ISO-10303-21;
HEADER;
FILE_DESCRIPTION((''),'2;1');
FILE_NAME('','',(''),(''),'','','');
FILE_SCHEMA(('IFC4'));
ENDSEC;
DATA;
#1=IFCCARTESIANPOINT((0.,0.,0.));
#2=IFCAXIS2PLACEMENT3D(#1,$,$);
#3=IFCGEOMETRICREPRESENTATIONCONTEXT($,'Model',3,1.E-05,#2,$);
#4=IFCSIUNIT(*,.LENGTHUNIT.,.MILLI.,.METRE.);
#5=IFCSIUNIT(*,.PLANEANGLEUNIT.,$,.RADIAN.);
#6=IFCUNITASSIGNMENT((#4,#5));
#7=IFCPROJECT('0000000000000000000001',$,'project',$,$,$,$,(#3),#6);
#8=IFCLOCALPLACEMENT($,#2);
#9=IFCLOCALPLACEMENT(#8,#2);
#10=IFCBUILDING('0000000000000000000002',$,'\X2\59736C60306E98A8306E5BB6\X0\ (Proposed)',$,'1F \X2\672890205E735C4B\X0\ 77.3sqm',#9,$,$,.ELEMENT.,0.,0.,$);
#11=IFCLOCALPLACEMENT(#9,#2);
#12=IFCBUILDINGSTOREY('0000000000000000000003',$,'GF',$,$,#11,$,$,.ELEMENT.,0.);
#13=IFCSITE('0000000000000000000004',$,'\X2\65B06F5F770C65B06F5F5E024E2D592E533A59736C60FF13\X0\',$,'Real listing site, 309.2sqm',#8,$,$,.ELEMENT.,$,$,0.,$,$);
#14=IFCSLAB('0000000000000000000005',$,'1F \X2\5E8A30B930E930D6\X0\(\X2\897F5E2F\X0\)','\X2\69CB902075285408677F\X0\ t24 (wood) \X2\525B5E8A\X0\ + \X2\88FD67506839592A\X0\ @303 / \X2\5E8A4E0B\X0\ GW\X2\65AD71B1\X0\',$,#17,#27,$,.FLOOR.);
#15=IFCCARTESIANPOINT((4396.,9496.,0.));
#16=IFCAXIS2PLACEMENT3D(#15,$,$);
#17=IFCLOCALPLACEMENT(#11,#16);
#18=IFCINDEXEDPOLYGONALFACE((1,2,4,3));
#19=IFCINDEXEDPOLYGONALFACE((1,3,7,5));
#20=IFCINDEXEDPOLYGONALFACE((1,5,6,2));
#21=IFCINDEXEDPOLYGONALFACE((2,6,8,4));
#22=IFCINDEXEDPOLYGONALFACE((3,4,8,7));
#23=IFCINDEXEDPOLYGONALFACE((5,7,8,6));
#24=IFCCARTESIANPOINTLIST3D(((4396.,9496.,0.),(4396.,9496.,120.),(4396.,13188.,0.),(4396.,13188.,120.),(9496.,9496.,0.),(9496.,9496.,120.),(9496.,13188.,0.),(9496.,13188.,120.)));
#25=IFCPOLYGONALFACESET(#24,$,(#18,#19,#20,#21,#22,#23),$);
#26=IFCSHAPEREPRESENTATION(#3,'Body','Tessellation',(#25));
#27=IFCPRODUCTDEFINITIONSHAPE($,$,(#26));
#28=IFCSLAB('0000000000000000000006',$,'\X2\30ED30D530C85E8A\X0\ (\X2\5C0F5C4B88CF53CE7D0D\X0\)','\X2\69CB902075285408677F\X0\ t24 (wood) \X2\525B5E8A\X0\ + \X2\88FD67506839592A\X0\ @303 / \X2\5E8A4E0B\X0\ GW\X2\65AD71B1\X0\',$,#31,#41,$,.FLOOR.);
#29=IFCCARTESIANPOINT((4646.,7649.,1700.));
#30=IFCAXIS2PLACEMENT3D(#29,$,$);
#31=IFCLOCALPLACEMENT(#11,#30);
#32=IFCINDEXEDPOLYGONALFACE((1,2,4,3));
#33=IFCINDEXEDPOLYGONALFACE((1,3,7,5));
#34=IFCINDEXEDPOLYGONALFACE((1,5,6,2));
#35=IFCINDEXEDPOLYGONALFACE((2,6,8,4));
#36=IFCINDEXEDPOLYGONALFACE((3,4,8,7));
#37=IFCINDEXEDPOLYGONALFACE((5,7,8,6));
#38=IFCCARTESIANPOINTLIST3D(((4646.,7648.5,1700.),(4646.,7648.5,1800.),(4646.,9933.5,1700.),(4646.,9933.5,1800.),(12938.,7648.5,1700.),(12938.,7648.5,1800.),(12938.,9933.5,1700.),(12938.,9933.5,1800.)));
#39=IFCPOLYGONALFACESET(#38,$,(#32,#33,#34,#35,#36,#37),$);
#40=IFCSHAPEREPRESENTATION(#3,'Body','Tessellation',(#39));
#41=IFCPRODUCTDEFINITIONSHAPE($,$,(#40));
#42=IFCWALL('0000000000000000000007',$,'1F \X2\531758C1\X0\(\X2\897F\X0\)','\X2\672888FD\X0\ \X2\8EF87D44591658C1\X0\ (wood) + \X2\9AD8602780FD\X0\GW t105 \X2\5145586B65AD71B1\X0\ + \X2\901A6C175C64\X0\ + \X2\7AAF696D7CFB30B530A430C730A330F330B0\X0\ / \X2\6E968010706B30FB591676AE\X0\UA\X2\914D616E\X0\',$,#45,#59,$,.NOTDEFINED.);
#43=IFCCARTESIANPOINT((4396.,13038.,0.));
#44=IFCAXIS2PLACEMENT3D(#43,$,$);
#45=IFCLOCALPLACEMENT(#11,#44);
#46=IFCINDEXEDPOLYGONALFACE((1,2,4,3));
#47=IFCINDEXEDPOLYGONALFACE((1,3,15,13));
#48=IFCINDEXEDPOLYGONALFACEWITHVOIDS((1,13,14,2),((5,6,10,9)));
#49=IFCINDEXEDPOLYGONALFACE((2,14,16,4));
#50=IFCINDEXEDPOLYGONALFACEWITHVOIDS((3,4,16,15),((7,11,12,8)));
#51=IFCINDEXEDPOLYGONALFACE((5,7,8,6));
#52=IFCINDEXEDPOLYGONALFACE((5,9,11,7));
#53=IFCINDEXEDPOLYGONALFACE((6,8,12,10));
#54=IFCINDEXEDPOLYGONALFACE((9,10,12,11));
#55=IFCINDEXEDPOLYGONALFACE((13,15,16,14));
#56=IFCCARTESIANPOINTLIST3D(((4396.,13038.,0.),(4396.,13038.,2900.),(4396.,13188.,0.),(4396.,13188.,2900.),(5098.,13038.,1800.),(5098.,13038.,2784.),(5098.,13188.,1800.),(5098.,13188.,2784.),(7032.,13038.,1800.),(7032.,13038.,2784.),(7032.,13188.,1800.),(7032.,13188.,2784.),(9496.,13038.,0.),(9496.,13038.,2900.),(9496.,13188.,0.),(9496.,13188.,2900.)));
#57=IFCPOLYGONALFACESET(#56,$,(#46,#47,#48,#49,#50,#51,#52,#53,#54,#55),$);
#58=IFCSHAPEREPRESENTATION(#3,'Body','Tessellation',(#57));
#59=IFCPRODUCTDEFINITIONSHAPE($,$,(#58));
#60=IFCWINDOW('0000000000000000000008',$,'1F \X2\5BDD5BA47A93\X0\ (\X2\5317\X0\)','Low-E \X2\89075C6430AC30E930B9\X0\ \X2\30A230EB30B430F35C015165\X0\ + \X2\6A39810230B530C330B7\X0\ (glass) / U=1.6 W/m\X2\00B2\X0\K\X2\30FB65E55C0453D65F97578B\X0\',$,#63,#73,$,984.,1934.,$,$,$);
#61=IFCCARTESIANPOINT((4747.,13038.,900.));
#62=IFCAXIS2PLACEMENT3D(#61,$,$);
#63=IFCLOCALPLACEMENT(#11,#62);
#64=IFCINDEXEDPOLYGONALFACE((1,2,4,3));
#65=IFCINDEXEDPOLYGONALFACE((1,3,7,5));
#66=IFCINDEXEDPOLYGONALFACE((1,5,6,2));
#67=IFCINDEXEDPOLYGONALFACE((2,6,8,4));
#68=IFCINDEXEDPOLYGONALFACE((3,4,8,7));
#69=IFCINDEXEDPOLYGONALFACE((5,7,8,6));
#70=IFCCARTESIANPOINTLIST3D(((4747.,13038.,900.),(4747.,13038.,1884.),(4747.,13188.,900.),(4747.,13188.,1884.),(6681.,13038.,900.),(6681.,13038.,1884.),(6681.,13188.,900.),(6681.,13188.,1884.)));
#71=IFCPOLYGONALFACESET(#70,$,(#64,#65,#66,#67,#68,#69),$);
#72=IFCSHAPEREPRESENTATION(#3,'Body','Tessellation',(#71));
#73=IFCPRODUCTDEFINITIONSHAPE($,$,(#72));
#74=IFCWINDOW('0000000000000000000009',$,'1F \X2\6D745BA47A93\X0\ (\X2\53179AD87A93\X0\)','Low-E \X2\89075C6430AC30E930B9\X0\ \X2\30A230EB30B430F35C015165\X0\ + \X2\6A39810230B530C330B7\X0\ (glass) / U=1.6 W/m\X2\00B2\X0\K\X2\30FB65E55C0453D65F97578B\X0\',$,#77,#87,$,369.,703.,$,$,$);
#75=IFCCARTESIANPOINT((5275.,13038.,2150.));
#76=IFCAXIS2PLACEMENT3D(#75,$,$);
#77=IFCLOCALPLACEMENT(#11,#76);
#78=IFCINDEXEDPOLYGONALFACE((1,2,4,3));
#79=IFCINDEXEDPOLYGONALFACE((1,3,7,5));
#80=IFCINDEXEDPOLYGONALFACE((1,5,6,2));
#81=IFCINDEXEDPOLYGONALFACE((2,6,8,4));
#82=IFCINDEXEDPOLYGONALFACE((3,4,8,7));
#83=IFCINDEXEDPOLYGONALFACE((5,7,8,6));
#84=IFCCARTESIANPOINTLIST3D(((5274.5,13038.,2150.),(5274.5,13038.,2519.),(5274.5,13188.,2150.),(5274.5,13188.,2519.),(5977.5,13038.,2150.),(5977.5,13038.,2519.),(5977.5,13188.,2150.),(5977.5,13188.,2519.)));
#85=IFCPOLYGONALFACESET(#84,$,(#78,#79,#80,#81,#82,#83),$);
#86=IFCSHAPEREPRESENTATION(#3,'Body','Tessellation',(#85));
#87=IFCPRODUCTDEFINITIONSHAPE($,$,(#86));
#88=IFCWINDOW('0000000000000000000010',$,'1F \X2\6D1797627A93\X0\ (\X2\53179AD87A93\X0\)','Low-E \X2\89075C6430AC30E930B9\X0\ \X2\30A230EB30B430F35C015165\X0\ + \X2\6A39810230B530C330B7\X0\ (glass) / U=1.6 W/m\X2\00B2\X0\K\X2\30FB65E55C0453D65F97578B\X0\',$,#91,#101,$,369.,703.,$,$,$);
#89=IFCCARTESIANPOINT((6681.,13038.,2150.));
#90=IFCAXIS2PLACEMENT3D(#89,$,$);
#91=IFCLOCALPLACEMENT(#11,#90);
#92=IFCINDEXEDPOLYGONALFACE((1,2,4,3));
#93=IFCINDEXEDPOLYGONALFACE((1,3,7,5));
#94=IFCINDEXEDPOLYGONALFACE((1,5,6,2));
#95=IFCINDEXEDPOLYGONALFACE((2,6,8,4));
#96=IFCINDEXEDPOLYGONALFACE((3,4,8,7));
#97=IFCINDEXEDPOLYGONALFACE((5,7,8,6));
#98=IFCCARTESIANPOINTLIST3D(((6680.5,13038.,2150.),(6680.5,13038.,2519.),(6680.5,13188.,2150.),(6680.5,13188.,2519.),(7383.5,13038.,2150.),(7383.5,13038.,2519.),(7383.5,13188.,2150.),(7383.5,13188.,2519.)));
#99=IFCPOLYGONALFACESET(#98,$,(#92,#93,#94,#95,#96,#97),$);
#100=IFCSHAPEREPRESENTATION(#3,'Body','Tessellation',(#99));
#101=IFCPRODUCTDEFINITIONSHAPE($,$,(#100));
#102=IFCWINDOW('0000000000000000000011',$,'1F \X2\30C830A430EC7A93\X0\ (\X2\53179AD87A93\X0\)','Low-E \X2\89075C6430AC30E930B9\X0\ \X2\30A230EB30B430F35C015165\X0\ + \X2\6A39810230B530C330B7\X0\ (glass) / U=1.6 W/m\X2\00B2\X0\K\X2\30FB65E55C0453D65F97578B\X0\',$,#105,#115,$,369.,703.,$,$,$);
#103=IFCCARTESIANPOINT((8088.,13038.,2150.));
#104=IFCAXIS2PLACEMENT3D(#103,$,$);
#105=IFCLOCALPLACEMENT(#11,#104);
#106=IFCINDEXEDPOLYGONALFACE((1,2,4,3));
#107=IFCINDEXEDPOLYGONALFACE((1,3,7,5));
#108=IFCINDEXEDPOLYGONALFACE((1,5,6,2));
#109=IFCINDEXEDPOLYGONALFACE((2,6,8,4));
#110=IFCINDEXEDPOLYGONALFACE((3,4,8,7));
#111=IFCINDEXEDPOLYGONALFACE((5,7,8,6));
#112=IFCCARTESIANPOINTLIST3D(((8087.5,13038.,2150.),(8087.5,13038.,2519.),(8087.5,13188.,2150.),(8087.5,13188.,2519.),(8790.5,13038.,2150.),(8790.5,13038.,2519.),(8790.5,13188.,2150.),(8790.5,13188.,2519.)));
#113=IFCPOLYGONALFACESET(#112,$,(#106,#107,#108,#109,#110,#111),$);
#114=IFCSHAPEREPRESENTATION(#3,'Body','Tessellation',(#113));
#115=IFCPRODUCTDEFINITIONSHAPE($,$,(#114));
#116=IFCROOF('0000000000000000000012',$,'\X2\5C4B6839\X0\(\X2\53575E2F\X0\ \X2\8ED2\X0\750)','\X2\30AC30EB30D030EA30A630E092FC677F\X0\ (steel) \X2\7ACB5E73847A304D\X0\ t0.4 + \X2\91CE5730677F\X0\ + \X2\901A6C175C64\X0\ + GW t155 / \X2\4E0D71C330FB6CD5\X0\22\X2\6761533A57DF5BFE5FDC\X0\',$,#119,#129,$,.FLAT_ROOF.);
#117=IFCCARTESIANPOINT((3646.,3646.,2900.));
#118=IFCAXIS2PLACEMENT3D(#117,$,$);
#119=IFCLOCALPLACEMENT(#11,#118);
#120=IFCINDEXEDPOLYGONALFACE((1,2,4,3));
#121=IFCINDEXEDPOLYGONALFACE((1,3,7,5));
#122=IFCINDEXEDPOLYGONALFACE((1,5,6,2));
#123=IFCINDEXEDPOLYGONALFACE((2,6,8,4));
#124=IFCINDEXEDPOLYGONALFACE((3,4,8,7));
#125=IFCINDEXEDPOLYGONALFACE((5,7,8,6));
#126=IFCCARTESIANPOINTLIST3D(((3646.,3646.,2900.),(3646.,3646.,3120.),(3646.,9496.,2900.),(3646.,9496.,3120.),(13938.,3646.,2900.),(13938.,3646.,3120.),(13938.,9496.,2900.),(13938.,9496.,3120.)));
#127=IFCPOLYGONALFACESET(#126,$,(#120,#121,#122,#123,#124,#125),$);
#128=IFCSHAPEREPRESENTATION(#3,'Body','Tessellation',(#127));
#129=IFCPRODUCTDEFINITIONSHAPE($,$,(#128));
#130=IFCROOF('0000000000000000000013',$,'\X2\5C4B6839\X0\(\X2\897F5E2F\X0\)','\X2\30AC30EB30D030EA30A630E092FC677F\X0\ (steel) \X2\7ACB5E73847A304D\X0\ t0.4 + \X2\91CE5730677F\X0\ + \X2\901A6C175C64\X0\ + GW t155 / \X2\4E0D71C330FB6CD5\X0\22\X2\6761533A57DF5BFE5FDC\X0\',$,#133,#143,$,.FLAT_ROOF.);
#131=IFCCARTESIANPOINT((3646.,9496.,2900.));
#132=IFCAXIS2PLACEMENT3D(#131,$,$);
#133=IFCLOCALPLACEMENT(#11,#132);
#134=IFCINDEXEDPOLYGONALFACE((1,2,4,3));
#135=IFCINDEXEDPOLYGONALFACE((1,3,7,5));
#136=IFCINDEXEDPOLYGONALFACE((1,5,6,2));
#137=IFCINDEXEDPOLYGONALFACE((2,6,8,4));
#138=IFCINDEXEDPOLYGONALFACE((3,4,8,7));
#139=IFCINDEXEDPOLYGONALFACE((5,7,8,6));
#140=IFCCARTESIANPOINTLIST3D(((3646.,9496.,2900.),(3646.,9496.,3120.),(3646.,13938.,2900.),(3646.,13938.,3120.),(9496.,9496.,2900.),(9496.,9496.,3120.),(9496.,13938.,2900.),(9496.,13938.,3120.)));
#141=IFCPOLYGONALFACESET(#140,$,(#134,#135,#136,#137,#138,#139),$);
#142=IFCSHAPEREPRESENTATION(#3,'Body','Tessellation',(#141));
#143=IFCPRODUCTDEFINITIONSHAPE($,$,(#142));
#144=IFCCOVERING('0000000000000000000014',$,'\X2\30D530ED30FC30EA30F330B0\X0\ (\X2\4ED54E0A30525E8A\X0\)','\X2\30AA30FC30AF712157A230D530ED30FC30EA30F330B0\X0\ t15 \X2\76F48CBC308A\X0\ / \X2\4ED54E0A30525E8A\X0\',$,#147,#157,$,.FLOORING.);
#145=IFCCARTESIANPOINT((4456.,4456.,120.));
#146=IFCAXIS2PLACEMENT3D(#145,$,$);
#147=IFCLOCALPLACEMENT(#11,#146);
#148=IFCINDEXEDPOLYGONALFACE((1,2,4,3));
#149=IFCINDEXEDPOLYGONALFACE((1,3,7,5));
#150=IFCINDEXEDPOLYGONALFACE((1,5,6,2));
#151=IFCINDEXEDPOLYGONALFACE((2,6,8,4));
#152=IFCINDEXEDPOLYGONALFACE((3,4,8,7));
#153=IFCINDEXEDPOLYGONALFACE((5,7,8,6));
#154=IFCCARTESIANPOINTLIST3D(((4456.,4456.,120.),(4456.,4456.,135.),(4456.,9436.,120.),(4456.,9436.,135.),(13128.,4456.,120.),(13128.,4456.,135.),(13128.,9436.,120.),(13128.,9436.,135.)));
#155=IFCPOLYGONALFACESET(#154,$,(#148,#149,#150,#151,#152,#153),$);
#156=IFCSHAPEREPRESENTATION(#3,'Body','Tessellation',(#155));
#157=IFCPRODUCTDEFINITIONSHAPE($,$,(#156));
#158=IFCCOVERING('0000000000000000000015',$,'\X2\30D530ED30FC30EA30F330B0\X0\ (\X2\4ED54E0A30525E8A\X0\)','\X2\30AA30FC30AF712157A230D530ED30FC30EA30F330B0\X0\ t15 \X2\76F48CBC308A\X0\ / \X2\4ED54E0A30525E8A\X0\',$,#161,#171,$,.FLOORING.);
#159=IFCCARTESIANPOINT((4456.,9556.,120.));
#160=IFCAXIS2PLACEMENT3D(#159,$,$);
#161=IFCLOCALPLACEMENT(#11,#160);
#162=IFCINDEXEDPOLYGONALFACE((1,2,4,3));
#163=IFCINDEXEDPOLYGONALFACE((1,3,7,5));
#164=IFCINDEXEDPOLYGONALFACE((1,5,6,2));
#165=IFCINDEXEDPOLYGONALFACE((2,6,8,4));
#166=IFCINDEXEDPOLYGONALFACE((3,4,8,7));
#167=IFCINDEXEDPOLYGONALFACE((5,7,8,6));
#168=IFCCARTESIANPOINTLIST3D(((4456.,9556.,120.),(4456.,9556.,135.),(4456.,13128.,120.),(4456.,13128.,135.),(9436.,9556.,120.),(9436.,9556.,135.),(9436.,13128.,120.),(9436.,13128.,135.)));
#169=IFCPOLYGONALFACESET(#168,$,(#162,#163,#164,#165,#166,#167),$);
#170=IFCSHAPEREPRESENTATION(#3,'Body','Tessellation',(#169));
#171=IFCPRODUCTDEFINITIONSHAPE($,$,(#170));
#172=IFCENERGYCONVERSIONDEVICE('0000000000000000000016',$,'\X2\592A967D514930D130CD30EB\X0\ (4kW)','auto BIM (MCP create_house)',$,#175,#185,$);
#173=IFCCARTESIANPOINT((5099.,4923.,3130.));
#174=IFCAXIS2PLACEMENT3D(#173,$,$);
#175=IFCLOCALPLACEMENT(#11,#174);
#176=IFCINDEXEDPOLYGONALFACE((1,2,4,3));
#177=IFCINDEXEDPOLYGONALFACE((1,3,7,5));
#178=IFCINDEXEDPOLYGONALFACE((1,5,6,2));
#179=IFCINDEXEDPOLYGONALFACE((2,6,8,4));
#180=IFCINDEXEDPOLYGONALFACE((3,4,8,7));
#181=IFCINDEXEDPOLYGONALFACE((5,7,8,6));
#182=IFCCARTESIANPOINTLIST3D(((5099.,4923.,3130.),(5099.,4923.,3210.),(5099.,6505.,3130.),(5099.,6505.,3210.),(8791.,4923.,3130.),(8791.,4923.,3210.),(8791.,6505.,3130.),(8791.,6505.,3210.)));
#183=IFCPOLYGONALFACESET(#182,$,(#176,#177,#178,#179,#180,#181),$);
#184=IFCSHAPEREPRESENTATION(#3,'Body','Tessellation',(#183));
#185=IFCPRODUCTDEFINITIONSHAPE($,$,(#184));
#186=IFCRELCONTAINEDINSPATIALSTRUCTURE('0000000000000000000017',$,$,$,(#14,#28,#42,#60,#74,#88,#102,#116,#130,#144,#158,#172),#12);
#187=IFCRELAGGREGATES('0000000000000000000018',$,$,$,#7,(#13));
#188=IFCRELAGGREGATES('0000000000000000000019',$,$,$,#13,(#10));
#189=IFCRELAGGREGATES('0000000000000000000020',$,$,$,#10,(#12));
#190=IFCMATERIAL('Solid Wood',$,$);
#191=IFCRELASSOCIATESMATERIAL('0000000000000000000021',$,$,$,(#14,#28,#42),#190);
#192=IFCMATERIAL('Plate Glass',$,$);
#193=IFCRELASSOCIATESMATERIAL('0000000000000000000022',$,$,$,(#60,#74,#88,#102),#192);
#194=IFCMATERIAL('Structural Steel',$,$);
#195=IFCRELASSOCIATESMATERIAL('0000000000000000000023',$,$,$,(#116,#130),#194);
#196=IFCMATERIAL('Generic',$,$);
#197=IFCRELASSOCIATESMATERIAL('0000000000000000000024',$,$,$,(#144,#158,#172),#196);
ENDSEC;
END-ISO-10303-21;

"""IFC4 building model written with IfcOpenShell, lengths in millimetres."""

from ifc_helpers import new_model, si_unit, frame, frame_2d, origin, place, context, project, spatial, rectangle, extrude, material, element, fill, save


model = new_model("IFC4")

# Units and contexts
model_context = context("Model", 3, precision=1e-05, world=origin())
ifc_project = project(units=[si_unit("LENGTHUNIT", "METRE", prefix="MILLI"), si_unit("PLANEANGLEUNIT", "RADIAN")], contexts=[model_context])

# Site, building, storey
site_placement = place(None, origin())
site = spatial("IfcSite", under=ifc_project, at=site_placement, Name="新潟県新潟市中央区女池３", ObjectType="Real listing site, 309.2sqm", CompositionType="ELEMENT", RefElevation=0.0)
building_placement = place(site_placement, origin())
building = spatial("IfcBuilding", under=site, at=building_placement, Name="女池の風の家 (Proposed)", ObjectType="1F 木造平屋 77.3sqm", CompositionType="ELEMENT", ElevationOfRefHeight=0.0, ElevationOfTerrain=0.0)
storey_placement = place(building_placement, origin())
storey = spatial("IfcBuildingStorey", under=building, at=storey_placement, Name="GF", CompositionType="ELEMENT", Elevation=0.0)

# Slabs
ifc_material_1 = material(Name="Solid Wood")
slab_1_placement = place(storey_placement, frame((4396.0, 9496.0, 0.0)))
element("IfcSlab", 1, at=slab_1_placement, inside=storey, material=ifc_material_1, Name="1F 床スラブ(西帯)", Description="構造用合板 t24 (wood) 剛床 + 製材根太 @303 / 床下 GW断熱", PredefinedType="FLOOR", context=model_context, shape_type="SweptSolid", body=[
    extrude(rectangle(XDim=5100.0, YDim=3692.0, at=frame_2d((2550.0, 1846.0))), frame((4396.0, 9496.0, 0.0)), (0.0, 0.0, 1.0), 120.0),
])
slab_2_placement = place(storey_placement, frame((4646.0, 7649.0, 1700.0)))
element("IfcSlab", 2, at=slab_2_placement, inside=storey, material=ifc_material_1, Name="ロフト床 (小屋裏収納)", Description="構造用合板 t24 (wood) 剛床 + 製材根太 @303 / 床下 GW断熱", PredefinedType="FLOOR", context=model_context, shape_type="SweptSolid", body=[
    extrude(rectangle(XDim=8292.0, YDim=2285.0, at=frame_2d((4146.0, 1142.0))), frame((4646.0, 7649.0, 1700.0)), (0.0, 0.0, 1.0), 100.0),
])

# Shared definitions
ifc_material_2 = material(Name="Plate Glass")

# Wall, openings, windows
wall_1_placement = place(storey_placement, frame((4396.0, 13038.0, 0.0)))
wall_1 = element("IfcWall", 3, at=wall_1_placement, inside=storey, material=ifc_material_1, Name="1F 北壁(西)", Description="木製 軸組外壁 (wood) + 高性能GW t105 充填断熱 + 通気層 + 窯業系サイディング / 準耐火・外皮UA配慮", PredefinedType="NOTDEFINED", context=model_context, shape_type="SweptSolid", body=[
    extrude(rectangle(XDim=5100.0, YDim=150.0, at=frame_2d((2550.0, 75.0))), frame((4396.0, 13038.0, 0.0)), (0.0, 0.0, 1.0), 2900.0),
])
opening_1_placement = place(storey_placement, frame((4747.0, 13038.0, 900.0)))
opening_1 = element("IfcOpeningElement", 4, at=opening_1_placement, cuts=wall_1, PredefinedType="NOTDEFINED", context=model_context, shape_type="SweptSolid", body=[
    extrude(rectangle(XDim=1934.0, YDim=150.0, at=frame_2d((967.0, 75.0))), frame((4747.0, 13038.0, 900.0)), (0.0, 0.0, 1.0), 984.0),
])
opening_2_placement = place(storey_placement, frame((5275.0, 13038.0, 2150.0)))
opening_2 = element("IfcOpeningElement", 5, at=opening_2_placement, cuts=wall_1, PredefinedType="NOTDEFINED", context=model_context, shape_type="SweptSolid", body=[
    extrude(rectangle(XDim=703.0, YDim=150.0, at=frame_2d((351.0, 75.0))), frame((5275.0, 13038.0, 2150.0)), (0.0, 0.0, 1.0), 369.0),
])
opening_3_placement = place(storey_placement, frame((6681.0, 13038.0, 2150.0)))
opening_3 = element("IfcOpeningElement", 6, at=opening_3_placement, cuts=wall_1, PredefinedType="NOTDEFINED", context=model_context, shape_type="SweptSolid", body=[
    extrude(rectangle(XDim=703.0, YDim=150.0, at=frame_2d((351.0, 75.0))), frame((6681.0, 13038.0, 2150.0)), (0.0, 0.0, 1.0), 369.0),
])
opening_4_placement = place(storey_placement, frame((8088.0, 13038.0, 2150.0)))
opening_4 = element("IfcOpeningElement", 7, at=opening_4_placement, cuts=wall_1, PredefinedType="NOTDEFINED", context=model_context, shape_type="SweptSolid", body=[
    extrude(rectangle(XDim=703.0, YDim=150.0, at=frame_2d((351.0, 75.0))), frame((8088.0, 13038.0, 2150.0)), (0.0, 0.0, 1.0), 369.0),
])
window_1_placement = place(storey_placement, frame((4747.0, 13038.0, 900.0)))
window_1 = element("IfcWindow", 8, at=window_1_placement, inside=storey, material=ifc_material_2, Name="1F 寝室窓 (北)", Description="Low-E 複層ガラス アルゴン封入 + 樹脂サッシ (glass) / U=1.6 W/m²K・日射取得型", OverallHeight=984.0, OverallWidth=1934.0, context=model_context, shape_type="SweptSolid", body=[
    extrude(rectangle(XDim=1934.0, YDim=150.0, at=frame_2d((967.0, 75.0))), frame((4747.0, 13038.0, 900.0)), (0.0, 0.0, 1.0), 984.0),
])
fill(opening_1, window_1)
window_2_placement = place(storey_placement, frame((5275.0, 13038.0, 2150.0)))
window_2 = element("IfcWindow", 9, at=window_2_placement, inside=storey, material=ifc_material_2, Name="1F 浴室窓 (北高窓)", Description="Low-E 複層ガラス アルゴン封入 + 樹脂サッシ (glass) / U=1.6 W/m²K・日射取得型", OverallHeight=369.0, OverallWidth=703.0, context=model_context, shape_type="SweptSolid", body=[
    extrude(rectangle(XDim=703.0, YDim=150.0, at=frame_2d((351.0, 75.0))), frame((5275.0, 13038.0, 2150.0)), (0.0, 0.0, 1.0), 369.0),
])
fill(opening_2, window_2)
window_3_placement = place(storey_placement, frame((6681.0, 13038.0, 2150.0)))
window_3 = element("IfcWindow", 10, at=window_3_placement, inside=storey, material=ifc_material_2, Name="1F 洗面窓 (北高窓)", Description="Low-E 複層ガラス アルゴン封入 + 樹脂サッシ (glass) / U=1.6 W/m²K・日射取得型", OverallHeight=369.0, OverallWidth=703.0, context=model_context, shape_type="SweptSolid", body=[
    extrude(rectangle(XDim=703.0, YDim=150.0, at=frame_2d((351.0, 75.0))), frame((6681.0, 13038.0, 2150.0)), (0.0, 0.0, 1.0), 369.0),
])
fill(opening_3, window_3)
window_4_placement = place(storey_placement, frame((8088.0, 13038.0, 2150.0)))
window_4 = element("IfcWindow", 11, at=window_4_placement, inside=storey, material=ifc_material_2, Name="1F トイレ窓 (北高窓)", Description="Low-E 複層ガラス アルゴン封入 + 樹脂サッシ (glass) / U=1.6 W/m²K・日射取得型", OverallHeight=369.0, OverallWidth=703.0, context=model_context, shape_type="SweptSolid", body=[
    extrude(rectangle(XDim=703.0, YDim=150.0, at=frame_2d((351.0, 75.0))), frame((8088.0, 13038.0, 2150.0)), (0.0, 0.0, 1.0), 369.0),
])
fill(opening_4, window_4)

# Roofs
ifc_material_3 = material(Name="Structural Steel")
roof_1_placement = place(storey_placement, frame((3646.0, 3646.0, 2900.0)))
element("IfcRoof", 12, at=roof_1_placement, inside=storey, material=ifc_material_3, Name="屋根(南帯 軒750)", Description="ガルバリウム鋼板 (steel) 立平葺き t0.4 + 野地板 + 通気層 + GW t155 / 不燃・法22条区域対応", PredefinedType="FLAT_ROOF", context=model_context, shape_type="SweptSolid", body=[
    extrude(rectangle(XDim=10292.0, YDim=5850.0, at=frame_2d((5146.0, 2925.0))), frame((3646.0, 3646.0, 2900.0)), (0.0, 0.0, 1.0), 220.0),
])
roof_2_placement = place(storey_placement, frame((3646.0, 9496.0, 2900.0)))
element("IfcRoof", 13, at=roof_2_placement, inside=storey, material=ifc_material_3, Name="屋根(西帯)", Description="ガルバリウム鋼板 (steel) 立平葺き t0.4 + 野地板 + 通気層 + GW t155 / 不燃・法22条区域対応", PredefinedType="FLAT_ROOF", context=model_context, shape_type="SweptSolid", body=[
    extrude(rectangle(XDim=5850.0, YDim=4442.0, at=frame_2d((2925.0, 2221.0))), frame((3646.0, 9496.0, 2900.0)), (0.0, 0.0, 1.0), 220.0),
])

# Coverings
ifc_material_4 = material(Name="Generic")
covering_1_placement = place(storey_placement, frame((4456.0, 4456.0, 120.0)))
element("IfcCovering", 14, at=covering_1_placement, inside=storey, material=ifc_material_4, Name="フローリング (仕上げ床)", Description="オーク無垢フローリング t15 直貼り / 仕上げ床", PredefinedType="FLOORING", context=model_context, shape_type="SweptSolid", body=[
    extrude(rectangle(XDim=8672.0, YDim=4980.0, at=frame_2d((4336.0, 2490.0))), frame((4456.0, 4456.0, 120.0)), (0.0, 0.0, 1.0), 15.0),
])
covering_2_placement = place(storey_placement, frame((4456.0, 9556.0, 120.0)))
element("IfcCovering", 15, at=covering_2_placement, inside=storey, material=ifc_material_4, Name="フローリング (仕上げ床)", Description="オーク無垢フローリング t15 直貼り / 仕上げ床", PredefinedType="FLOORING", context=model_context, shape_type="SweptSolid", body=[
    extrude(rectangle(XDim=4980.0, YDim=3572.0, at=frame_2d((2490.0, 1786.0))), frame((4456.0, 9556.0, 120.0)), (0.0, 0.0, 1.0), 15.0),
])

# Energy conversion device
energy_conversion_device_placement = place(storey_placement, frame((5099.0, 4923.0, 3130.0)))
element("IfcEnergyConversionDevice", 16, at=energy_conversion_device_placement, inside=storey, material=ifc_material_4, Name="太陽光パネル (4kW)", Description="auto BIM (MCP create_house)", context=model_context, shape_type="SweptSolid", body=[
    extrude(rectangle(XDim=3692.0, YDim=1582.0, at=frame_2d((1846.0, 791.0))), frame((5099.0, 4923.0, 3130.0)), (0.0, 0.0, 1.0), 80.0),
])

save(model, "model.ifc")
